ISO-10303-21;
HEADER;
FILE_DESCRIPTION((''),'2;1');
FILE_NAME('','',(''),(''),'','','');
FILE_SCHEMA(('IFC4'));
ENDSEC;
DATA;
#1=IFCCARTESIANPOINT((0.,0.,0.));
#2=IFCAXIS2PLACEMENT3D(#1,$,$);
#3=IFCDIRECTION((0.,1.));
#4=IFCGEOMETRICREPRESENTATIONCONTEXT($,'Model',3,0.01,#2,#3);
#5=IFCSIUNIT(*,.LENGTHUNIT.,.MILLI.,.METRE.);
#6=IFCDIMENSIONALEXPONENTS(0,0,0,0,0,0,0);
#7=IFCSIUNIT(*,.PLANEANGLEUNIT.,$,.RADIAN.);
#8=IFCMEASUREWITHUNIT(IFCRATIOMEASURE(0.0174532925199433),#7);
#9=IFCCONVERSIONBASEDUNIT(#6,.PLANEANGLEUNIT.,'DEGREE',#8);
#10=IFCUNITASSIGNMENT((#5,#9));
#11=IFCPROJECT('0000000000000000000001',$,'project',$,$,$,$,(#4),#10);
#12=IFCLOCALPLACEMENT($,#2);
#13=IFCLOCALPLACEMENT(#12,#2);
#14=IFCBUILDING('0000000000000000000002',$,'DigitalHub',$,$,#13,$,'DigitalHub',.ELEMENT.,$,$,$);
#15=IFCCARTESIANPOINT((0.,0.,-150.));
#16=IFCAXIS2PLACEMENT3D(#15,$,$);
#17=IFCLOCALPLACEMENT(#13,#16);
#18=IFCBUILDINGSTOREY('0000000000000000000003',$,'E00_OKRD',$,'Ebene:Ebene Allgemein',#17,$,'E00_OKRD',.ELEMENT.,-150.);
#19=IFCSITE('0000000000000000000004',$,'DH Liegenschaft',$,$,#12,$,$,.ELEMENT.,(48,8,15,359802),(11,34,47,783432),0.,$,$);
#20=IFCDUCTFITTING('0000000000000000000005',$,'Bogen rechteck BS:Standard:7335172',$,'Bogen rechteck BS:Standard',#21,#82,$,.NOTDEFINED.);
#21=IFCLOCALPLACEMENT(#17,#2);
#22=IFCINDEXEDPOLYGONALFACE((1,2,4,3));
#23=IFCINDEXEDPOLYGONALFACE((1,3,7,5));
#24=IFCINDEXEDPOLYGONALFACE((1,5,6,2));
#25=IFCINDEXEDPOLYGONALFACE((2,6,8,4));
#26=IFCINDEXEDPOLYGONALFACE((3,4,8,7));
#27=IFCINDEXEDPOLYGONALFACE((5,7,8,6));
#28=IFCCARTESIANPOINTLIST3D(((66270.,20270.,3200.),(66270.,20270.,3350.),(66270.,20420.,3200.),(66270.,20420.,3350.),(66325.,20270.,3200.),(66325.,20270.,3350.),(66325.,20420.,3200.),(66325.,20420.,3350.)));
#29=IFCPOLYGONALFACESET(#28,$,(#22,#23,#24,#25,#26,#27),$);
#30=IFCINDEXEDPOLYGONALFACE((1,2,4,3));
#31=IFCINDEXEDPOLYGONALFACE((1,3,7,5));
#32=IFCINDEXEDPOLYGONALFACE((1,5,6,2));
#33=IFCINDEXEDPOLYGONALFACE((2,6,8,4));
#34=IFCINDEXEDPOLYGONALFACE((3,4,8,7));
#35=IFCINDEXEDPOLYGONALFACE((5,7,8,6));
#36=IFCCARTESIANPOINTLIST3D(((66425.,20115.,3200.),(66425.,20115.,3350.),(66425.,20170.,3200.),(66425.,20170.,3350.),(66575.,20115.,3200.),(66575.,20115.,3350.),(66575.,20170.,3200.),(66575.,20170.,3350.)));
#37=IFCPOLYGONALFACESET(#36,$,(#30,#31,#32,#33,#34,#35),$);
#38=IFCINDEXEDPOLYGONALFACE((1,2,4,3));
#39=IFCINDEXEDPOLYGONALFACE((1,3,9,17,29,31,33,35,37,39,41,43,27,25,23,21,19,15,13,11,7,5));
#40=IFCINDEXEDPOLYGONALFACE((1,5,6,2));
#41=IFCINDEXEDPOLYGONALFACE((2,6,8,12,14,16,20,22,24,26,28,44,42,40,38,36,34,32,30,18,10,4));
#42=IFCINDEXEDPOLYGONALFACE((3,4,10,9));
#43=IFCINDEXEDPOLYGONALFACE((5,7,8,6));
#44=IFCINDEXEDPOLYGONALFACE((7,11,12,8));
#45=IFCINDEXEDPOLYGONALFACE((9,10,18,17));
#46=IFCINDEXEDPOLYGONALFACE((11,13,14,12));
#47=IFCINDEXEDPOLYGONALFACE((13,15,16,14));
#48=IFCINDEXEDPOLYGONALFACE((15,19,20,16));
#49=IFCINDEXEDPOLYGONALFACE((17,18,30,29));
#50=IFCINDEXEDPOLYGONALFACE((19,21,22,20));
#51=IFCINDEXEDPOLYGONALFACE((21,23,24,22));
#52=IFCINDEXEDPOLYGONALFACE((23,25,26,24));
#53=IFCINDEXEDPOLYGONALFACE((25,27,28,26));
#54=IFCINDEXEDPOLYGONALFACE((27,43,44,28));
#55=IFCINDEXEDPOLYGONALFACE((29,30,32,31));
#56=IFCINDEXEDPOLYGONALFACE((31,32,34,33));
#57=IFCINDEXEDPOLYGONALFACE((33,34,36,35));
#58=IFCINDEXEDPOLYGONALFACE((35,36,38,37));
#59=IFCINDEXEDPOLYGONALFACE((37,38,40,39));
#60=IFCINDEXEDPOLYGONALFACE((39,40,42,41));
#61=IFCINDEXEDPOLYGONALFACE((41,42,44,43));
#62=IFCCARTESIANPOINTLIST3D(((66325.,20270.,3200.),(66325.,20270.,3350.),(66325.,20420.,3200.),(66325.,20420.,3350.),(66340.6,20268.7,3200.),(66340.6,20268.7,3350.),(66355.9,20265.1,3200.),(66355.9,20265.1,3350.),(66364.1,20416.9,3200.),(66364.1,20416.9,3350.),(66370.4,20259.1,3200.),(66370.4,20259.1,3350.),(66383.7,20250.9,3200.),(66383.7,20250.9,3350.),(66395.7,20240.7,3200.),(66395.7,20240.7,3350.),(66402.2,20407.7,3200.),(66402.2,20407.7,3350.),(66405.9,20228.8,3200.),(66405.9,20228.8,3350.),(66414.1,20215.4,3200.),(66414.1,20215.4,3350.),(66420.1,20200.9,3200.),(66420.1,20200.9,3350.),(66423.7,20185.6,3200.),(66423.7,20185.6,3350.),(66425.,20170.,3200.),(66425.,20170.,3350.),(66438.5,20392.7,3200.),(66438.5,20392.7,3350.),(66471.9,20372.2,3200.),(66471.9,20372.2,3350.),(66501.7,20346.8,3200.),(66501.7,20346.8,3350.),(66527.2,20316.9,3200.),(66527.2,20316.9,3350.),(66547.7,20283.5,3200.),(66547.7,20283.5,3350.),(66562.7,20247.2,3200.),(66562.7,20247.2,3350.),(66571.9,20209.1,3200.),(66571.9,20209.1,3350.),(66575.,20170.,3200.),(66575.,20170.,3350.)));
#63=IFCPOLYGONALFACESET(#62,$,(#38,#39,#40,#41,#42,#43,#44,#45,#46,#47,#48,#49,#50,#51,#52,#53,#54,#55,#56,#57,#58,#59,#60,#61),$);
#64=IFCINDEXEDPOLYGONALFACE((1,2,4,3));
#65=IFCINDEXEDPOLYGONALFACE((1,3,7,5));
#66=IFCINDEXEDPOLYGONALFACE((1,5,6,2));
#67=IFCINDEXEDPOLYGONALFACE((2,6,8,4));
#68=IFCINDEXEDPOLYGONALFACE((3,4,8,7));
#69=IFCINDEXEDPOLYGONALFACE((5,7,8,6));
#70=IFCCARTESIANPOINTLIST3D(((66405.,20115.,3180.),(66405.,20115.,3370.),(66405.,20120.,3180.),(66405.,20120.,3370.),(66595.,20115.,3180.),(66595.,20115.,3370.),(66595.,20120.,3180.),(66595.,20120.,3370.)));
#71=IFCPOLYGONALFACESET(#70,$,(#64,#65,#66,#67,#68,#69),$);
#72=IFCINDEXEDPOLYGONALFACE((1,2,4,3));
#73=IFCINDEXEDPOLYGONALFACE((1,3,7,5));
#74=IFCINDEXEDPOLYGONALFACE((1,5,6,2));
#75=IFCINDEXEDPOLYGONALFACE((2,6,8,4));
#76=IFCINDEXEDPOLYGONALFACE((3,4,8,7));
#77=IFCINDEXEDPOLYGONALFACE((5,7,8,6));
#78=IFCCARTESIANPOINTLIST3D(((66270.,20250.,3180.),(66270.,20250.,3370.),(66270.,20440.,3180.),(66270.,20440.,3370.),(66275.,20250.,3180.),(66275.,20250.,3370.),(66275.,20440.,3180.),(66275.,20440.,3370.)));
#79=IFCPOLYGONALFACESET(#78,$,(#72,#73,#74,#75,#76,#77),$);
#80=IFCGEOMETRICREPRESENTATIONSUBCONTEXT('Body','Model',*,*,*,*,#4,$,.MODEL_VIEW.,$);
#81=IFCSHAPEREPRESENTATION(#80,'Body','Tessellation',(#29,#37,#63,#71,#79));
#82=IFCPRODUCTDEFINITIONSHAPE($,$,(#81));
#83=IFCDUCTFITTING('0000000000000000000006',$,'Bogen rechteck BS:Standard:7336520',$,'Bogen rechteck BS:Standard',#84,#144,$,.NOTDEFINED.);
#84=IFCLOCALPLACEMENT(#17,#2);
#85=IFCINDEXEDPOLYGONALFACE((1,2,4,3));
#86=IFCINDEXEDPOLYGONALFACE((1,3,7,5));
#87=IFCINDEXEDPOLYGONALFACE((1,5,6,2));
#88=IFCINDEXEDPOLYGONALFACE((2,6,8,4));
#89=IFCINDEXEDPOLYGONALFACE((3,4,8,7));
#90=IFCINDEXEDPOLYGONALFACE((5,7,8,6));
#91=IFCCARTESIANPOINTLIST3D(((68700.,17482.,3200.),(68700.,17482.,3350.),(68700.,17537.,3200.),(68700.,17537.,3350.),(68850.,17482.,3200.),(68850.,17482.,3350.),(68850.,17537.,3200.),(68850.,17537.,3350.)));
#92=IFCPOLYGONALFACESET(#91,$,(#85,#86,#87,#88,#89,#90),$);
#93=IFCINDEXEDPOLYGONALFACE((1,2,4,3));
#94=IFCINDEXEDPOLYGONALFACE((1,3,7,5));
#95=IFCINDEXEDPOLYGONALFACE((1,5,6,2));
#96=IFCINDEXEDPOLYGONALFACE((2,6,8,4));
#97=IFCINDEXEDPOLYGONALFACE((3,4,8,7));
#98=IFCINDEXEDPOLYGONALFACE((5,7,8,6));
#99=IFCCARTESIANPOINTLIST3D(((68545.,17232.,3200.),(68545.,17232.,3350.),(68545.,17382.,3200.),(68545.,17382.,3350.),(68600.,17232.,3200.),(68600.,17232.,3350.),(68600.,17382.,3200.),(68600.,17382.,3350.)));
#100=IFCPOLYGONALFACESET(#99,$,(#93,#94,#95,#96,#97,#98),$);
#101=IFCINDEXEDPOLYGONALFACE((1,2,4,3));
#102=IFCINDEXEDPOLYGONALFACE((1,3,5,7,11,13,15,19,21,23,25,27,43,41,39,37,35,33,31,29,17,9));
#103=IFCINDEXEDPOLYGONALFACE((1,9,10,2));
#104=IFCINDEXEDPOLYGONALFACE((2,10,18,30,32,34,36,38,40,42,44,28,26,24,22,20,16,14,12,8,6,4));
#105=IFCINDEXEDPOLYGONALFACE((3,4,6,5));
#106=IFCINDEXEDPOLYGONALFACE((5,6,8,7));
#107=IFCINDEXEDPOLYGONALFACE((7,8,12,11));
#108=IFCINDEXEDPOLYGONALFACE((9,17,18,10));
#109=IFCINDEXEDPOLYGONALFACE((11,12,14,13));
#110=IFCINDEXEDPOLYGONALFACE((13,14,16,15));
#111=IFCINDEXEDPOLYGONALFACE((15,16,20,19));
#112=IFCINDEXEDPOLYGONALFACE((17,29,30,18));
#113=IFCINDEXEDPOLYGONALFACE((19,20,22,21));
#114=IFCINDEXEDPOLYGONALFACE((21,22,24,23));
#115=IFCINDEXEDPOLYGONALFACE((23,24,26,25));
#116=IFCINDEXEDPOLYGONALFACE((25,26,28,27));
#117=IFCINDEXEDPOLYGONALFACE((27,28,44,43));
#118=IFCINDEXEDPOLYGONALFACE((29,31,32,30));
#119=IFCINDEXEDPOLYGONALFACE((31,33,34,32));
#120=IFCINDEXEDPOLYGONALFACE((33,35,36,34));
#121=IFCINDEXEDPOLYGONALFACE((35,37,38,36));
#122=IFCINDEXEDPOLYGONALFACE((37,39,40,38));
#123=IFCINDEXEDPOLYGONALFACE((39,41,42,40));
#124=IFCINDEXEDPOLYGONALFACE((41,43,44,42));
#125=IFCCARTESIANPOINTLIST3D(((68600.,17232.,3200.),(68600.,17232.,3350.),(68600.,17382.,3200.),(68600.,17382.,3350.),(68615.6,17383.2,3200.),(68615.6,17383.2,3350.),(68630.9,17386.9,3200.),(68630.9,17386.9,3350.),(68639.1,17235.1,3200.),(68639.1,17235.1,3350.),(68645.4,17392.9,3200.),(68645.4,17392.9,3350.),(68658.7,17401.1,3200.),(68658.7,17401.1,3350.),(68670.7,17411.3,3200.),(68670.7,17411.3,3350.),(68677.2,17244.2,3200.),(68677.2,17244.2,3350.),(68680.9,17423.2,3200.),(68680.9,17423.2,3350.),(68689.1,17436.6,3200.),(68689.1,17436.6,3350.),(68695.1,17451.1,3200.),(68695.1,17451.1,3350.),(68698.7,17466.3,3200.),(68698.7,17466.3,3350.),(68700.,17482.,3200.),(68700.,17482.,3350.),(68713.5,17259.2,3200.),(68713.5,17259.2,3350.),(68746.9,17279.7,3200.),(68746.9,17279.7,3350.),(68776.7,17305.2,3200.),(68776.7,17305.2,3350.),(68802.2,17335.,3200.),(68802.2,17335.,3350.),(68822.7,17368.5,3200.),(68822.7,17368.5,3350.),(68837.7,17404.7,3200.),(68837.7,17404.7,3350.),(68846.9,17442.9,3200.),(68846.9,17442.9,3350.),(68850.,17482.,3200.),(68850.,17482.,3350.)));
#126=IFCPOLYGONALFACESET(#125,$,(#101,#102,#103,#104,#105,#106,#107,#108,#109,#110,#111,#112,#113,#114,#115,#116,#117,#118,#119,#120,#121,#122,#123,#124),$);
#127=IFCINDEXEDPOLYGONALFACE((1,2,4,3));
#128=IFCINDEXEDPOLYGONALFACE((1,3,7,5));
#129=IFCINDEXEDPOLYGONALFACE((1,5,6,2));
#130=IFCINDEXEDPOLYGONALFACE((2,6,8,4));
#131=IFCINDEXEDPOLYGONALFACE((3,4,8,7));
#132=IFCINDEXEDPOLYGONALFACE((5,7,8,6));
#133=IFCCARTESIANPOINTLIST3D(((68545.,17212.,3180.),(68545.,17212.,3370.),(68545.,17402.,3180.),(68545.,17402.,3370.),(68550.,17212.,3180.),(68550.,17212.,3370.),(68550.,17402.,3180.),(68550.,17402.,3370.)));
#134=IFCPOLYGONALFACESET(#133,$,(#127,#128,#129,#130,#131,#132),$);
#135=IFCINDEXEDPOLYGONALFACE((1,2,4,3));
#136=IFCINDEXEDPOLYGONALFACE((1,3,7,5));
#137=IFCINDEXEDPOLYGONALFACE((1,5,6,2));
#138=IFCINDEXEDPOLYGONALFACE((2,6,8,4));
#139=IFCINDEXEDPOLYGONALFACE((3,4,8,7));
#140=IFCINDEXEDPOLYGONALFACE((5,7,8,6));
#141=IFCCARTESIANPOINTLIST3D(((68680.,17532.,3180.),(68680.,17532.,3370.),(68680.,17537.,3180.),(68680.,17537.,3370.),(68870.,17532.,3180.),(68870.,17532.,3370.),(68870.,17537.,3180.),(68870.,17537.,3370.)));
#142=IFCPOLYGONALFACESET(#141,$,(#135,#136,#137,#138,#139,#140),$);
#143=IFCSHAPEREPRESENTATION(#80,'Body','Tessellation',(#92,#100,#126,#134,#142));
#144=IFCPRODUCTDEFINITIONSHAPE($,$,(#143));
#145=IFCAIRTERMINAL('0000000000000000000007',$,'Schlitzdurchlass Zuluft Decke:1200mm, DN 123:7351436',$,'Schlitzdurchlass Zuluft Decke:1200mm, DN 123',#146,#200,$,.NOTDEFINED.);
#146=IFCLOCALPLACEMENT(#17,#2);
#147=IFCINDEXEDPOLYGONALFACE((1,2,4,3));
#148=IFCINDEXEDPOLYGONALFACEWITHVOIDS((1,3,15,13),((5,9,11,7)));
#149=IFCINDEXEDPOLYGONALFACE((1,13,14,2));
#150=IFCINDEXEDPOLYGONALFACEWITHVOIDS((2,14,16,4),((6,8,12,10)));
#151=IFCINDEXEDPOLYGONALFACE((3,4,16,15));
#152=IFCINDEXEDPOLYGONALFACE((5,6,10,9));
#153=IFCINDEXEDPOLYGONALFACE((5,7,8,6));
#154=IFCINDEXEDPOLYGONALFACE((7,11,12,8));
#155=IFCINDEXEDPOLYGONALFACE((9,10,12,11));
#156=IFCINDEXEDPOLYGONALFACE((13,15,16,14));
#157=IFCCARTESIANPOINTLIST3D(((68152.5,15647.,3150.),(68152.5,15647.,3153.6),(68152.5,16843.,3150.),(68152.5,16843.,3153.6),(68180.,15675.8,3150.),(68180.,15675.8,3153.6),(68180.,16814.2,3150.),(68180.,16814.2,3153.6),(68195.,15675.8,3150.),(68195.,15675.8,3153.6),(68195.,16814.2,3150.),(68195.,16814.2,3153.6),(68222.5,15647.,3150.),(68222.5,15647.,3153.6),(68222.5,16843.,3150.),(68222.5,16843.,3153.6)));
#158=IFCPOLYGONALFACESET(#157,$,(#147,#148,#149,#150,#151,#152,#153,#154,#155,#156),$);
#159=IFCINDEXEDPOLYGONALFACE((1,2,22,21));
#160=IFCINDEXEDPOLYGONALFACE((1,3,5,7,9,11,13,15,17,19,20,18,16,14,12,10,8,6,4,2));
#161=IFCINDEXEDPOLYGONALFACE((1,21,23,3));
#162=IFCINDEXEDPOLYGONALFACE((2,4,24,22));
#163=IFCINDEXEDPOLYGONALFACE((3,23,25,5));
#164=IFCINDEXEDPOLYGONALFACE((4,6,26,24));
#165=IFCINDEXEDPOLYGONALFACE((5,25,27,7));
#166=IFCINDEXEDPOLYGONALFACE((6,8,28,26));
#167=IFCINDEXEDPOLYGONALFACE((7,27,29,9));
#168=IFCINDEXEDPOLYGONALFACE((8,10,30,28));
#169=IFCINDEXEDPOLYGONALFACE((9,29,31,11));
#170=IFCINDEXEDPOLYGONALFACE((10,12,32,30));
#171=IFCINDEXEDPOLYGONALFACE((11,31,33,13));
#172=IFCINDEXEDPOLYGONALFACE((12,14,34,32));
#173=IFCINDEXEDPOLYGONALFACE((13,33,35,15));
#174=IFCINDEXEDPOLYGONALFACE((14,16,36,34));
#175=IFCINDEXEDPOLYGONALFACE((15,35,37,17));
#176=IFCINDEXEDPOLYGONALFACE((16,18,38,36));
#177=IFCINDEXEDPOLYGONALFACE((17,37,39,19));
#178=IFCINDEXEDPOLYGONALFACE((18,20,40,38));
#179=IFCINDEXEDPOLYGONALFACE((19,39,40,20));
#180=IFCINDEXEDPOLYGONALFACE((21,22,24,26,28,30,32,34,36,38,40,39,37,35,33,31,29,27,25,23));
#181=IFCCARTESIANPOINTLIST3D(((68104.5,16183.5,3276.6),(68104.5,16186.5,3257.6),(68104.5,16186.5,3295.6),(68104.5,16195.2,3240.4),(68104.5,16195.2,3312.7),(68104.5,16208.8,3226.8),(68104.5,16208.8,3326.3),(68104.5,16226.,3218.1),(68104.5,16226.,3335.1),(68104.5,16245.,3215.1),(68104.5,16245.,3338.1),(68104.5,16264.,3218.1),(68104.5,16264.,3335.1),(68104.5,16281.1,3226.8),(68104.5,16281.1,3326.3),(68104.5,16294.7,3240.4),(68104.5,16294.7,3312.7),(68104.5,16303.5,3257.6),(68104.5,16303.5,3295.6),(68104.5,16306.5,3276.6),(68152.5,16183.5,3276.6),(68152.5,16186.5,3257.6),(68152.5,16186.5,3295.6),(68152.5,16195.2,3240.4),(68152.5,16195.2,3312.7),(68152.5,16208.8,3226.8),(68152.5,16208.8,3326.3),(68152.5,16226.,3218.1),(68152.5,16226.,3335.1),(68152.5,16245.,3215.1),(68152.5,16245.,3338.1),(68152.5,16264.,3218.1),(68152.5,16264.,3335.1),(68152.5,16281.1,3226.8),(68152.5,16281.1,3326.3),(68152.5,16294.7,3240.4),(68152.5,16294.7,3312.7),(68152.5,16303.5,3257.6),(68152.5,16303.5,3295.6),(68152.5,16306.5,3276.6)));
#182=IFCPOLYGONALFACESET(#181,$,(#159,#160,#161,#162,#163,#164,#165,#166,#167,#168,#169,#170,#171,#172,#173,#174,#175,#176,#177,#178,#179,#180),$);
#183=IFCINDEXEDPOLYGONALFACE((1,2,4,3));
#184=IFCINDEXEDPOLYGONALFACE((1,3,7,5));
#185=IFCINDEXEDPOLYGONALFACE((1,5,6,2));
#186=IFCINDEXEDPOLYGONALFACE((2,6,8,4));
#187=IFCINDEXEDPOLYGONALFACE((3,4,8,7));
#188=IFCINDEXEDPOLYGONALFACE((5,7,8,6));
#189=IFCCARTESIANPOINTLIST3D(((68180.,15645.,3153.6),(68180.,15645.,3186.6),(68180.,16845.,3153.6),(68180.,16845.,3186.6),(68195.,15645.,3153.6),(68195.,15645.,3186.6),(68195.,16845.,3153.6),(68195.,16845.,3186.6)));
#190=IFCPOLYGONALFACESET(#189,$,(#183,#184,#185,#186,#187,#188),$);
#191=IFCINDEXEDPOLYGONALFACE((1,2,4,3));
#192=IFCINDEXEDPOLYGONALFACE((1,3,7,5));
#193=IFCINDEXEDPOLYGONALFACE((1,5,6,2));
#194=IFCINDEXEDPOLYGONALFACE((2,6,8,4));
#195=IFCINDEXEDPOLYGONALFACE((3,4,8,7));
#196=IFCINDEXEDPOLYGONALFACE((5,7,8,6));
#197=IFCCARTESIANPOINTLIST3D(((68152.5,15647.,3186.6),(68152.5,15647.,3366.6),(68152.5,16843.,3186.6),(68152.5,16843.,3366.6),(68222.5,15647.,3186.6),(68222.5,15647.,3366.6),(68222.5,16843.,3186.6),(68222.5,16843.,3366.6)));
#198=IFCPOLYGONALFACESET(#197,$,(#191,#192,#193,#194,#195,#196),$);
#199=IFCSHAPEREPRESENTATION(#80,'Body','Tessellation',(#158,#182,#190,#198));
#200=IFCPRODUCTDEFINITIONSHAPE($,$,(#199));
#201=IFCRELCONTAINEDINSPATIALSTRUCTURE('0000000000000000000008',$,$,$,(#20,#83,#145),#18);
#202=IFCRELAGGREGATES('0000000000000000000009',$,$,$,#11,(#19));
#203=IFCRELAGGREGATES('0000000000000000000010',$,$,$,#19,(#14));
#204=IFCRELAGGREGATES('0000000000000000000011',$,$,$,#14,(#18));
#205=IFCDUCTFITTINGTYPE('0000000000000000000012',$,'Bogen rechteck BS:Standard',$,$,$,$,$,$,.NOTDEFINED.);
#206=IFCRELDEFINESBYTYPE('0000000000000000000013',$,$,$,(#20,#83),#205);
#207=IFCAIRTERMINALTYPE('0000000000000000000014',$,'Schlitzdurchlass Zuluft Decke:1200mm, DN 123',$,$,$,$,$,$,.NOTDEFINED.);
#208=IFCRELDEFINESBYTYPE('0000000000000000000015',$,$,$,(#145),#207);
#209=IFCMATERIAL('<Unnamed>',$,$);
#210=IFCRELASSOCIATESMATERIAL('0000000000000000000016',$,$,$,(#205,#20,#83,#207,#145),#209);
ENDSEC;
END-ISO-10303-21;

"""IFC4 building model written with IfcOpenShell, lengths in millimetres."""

from ifc_helpers import new_model, entity, si_unit, converted_unit, direction, frame, origin, place, context, subcontext, project, spatial, indexed_curve, outline, extrude, source, transform, mapped, material, type_object, type_shapes, element, save


model = new_model("IFC4")

# Units and contexts
model_context = context("Model", 3, precision=0.01, world=origin(), true_north=direction((0.0, 1.0)))
body_context = subcontext(model_context, "Body", "Model", "MODEL_VIEW")
ifc_project = project(units=[si_unit("LENGTHUNIT", "METRE", prefix="MILLI"), converted_unit("PLANEANGLEUNIT", "DEGREE", entity("IfcRatioMeasure", 0.0174532925199433), si_unit("PLANEANGLEUNIT", "RADIAN"), dimensions=[0, 0, 0, 0, 0, 0, 0])], contexts=[model_context])

# Site, building, storey
site_placement = place(None, origin())
site = spatial("IfcSite", under=ifc_project, at=site_placement, Name="DH Liegenschaft", CompositionType="ELEMENT", RefLatitude=(48, 8, 15, 359802), RefLongitude=(11, 34, 47, 783432), RefElevation=0.0)
building_placement = place(site_placement, origin())
building = spatial("IfcBuilding", under=site, at=building_placement, Name="DigitalHub", LongName="DigitalHub", CompositionType="ELEMENT")
storey_placement = place(building_placement, frame((0.0, 0.0, -150.0)))
storey = spatial("IfcBuildingStorey", under=building, at=storey_placement, Name="E00_OKRD", ObjectType="Ebene:Ebene Allgemein", LongName="E00_OKRD", CompositionType="ELEMENT", Elevation=-150.0)

# Shared definitions
ifc_material_1 = material(Name="<Unnamed>")

# Duct fittings
duct_fitting_type_1 = type_object("IfcDuctFittingType", Name="Bogen rechteck BS:Standard", PredefinedType="NOTDEFINED", material=ifc_material_1)
shared_shape_1 = source(origin(), body_context, "Body", "SweptSolid", [
    extrude(outline(indexed_curve([(-27.5, -75.0), (27.5, -75.0), (27.5, 75.0), (-27.5, 75.0), (-27.5, -75.0)], self_intersect=False)), frame((0.0, 202.5, -75.0), z_axis=(0.0, 0.0, 1.0), x_axis=(0.0, 1.0, 0.0)), (0.0, 0.0, 1.0), 150.0),
    extrude(outline(indexed_curve([(-75.0, -27.5), (75.0, -27.5), (75.0, 27.5), (-75.0, 27.5), (-75.0, -27.5)], self_intersect=False)), frame((-202.5, 0.0, -75.0), z_axis=(0.0, 0.0, 1.0), x_axis=(0.0, -1.0, 0.0)), (0.0, 0.0, 1.0), 150.0),
    extrude(outline(indexed_curve([(-162.5, -87.5), (-12.5, -87.5), (-11.3, -71.9), (-7.6, -56.6), (-1.6, -42.1), (6.6, -28.7), (16.8, -16.8), (28.7, -6.6), (42.1, 1.6), (56.6, 7.6), (71.9, 11.3), (87.5, 12.5), (87.5, 162.5), (48.4, 159.4), (10.2, 150.3), (-26.0, 135.3), (-59.4, 114.8), (-89.3, 89.3), (-114.8, 59.4), (-135.3, 26.0), (-150.3, -10.2), (-159.4, -48.4), (-162.5, -87.5)], self_intersect=False)), frame((-87.5, 87.5, -75.0), z_axis=(0.0, 0.0, 1.0), x_axis=(-1.0, 0.0, 0.0)), (0.0, 0.0, 1.0), 150.0),
    extrude(outline(indexed_curve([(-2.5, -95.0), (2.5, -95.0), (2.5, 95.0), (-2.5, 95.0), (-2.5, -95.0)], self_intersect=False)), frame((-227.5, 0.0, -95.0)), (0.0, 0.0, 1.0), 190.0),
    extrude(outline(indexed_curve([(-2.5, -95.0), (2.5, -95.0), (2.5, 95.0), (-2.5, 95.0), (-2.5, -95.0)], self_intersect=False)), frame((0.0, 227.5, -95.0), z_axis=(0.0, 0.0, 1.0), x_axis=(0.0, 1.0, 0.0)), (0.0, 0.0, 1.0), 190.0),
])
type_shapes(duct_fitting_type_1, [shared_shape_1])
duct_fitting_1_placement = place(storey_placement, frame((66500.0, 20345.0, 3275.0), z_axis=(0.0, 0.0, 1.0), x_axis=(0.0, 1.0, 0.0)))
element("IfcDuctFitting", 1, at=duct_fitting_1_placement, inside=storey, type_object=duct_fitting_type_1, material=ifc_material_1, Name="Bogen rechteck BS:Standard:7335172", ObjectType="Bogen rechteck BS:Standard", PredefinedType="NOTDEFINED", context=body_context, shape_type="MappedRepresentation", body=[
    mapped(shared_shape_1, transform((0.0, 0.0, 0.0), scale=1.0)),
])
duct_fitting_2_placement = place(storey_placement, frame((68775.0, 17307.0, 3275.0)))
element("IfcDuctFitting", 2, at=duct_fitting_2_placement, inside=storey, type_object=duct_fitting_type_1, material=ifc_material_1, Name="Bogen rechteck BS:Standard:7336520", ObjectType="Bogen rechteck BS:Standard", PredefinedType="NOTDEFINED", context=body_context, shape_type="MappedRepresentation", body=[
    mapped(shared_shape_1, transform((0.0, 0.0, 0.0), scale=1.0)),
])

# Air terminal
air_terminal_type_1 = type_object("IfcAirTerminalType", Name="Schlitzdurchlass Zuluft Decke:1200mm, DN 123", PredefinedType="NOTDEFINED", material=ifc_material_1)
shared_shape_2 = source(origin(), body_context, "Body", "SweptSolid", [
    extrude(outline(indexed_curve([(-598.0, -35.0), (598.0, -35.0), (598.0, 35.0), (-598.0, 35.0), (-598.0, -35.0)], self_intersect=False), holes=[indexed_curve([(-569.2, -7.5), (-569.2, 7.5), (569.2, 7.5), (569.2, -7.5), (-569.2, -7.5)], self_intersect=False)]), frame((600.0, 35.0, 0.0), z_axis=(0.0, 0.0, 1.0), x_axis=(-1.0, 0.0, 0.0)), (0.0, 0.0, 1.0), 3.6),
    extrude(outline(indexed_curve([(61.5, 0.0), (58.5, 19.0), (49.8, 36.1), (36.1, 49.8), (19.0, 58.5), (0.0, 61.5), (-19.0, 58.5), (-36.1, 49.8), (-49.8, 36.1), (-58.5, 19.0), (-61.5, 0.0), (-58.5, -19.0), (-49.8, -36.1), (-36.1, -49.8), (-19.0, -58.5), (0.0, -61.5), (19.0, -58.5), (36.1, -49.8), (49.8, -36.1), (58.5, -19.0), (61.5, 0.0)], self_intersect=False)), frame((600.0, 70.0, 126.6), z_axis=(0.0, 1.0, 0.0), x_axis=(-1.0, 0.0, 0.0)), (0.0, 0.0, 1.0), 48.0),
    extrude(outline(indexed_curve([(-600.0, -7.5), (600.0, -7.5), (600.0, 7.5), (-600.0, 7.5), (-600.0, -7.5)], self_intersect=False)), frame((600.0, 35.0, 3.6), z_axis=(0.0, 0.0, 1.0), x_axis=(-1.0, 0.0, 0.0)), (0.0, 0.0, 1.0), 33.0),
    extrude(outline(indexed_curve([(-598.0, -35.0), (598.0, -35.0), (598.0, 35.0), (-598.0, 35.0), (-598.0, -35.0)], self_intersect=False)), frame((600.0, 35.0, 36.6), z_axis=(0.0, 0.0, 1.0), x_axis=(-1.0, 0.0, 0.0)), (0.0, 0.0, 1.0), 180.0),
])
type_shapes(air_terminal_type_1, [shared_shape_2])
air_terminal_1_placement = place(storey_placement, frame((68222.5, 15645.0, 3150.0), z_axis=(0.0, 0.0, 1.0), x_axis=(0.0, 1.0, 0.0)))
element("IfcAirTerminal", 3, at=air_terminal_1_placement, inside=storey, type_object=air_terminal_type_1, material=ifc_material_1, Name="Schlitzdurchlass Zuluft Decke:1200mm, DN 123:7351436", ObjectType="Schlitzdurchlass Zuluft Decke:1200mm, DN 123", PredefinedType="NOTDEFINED", context=body_context, shape_type="MappedRepresentation", body=[
    mapped(shared_shape_2, transform((0.0, 0.0, 0.0), scale=1.0)),
])

save(model, "model.ifc")
